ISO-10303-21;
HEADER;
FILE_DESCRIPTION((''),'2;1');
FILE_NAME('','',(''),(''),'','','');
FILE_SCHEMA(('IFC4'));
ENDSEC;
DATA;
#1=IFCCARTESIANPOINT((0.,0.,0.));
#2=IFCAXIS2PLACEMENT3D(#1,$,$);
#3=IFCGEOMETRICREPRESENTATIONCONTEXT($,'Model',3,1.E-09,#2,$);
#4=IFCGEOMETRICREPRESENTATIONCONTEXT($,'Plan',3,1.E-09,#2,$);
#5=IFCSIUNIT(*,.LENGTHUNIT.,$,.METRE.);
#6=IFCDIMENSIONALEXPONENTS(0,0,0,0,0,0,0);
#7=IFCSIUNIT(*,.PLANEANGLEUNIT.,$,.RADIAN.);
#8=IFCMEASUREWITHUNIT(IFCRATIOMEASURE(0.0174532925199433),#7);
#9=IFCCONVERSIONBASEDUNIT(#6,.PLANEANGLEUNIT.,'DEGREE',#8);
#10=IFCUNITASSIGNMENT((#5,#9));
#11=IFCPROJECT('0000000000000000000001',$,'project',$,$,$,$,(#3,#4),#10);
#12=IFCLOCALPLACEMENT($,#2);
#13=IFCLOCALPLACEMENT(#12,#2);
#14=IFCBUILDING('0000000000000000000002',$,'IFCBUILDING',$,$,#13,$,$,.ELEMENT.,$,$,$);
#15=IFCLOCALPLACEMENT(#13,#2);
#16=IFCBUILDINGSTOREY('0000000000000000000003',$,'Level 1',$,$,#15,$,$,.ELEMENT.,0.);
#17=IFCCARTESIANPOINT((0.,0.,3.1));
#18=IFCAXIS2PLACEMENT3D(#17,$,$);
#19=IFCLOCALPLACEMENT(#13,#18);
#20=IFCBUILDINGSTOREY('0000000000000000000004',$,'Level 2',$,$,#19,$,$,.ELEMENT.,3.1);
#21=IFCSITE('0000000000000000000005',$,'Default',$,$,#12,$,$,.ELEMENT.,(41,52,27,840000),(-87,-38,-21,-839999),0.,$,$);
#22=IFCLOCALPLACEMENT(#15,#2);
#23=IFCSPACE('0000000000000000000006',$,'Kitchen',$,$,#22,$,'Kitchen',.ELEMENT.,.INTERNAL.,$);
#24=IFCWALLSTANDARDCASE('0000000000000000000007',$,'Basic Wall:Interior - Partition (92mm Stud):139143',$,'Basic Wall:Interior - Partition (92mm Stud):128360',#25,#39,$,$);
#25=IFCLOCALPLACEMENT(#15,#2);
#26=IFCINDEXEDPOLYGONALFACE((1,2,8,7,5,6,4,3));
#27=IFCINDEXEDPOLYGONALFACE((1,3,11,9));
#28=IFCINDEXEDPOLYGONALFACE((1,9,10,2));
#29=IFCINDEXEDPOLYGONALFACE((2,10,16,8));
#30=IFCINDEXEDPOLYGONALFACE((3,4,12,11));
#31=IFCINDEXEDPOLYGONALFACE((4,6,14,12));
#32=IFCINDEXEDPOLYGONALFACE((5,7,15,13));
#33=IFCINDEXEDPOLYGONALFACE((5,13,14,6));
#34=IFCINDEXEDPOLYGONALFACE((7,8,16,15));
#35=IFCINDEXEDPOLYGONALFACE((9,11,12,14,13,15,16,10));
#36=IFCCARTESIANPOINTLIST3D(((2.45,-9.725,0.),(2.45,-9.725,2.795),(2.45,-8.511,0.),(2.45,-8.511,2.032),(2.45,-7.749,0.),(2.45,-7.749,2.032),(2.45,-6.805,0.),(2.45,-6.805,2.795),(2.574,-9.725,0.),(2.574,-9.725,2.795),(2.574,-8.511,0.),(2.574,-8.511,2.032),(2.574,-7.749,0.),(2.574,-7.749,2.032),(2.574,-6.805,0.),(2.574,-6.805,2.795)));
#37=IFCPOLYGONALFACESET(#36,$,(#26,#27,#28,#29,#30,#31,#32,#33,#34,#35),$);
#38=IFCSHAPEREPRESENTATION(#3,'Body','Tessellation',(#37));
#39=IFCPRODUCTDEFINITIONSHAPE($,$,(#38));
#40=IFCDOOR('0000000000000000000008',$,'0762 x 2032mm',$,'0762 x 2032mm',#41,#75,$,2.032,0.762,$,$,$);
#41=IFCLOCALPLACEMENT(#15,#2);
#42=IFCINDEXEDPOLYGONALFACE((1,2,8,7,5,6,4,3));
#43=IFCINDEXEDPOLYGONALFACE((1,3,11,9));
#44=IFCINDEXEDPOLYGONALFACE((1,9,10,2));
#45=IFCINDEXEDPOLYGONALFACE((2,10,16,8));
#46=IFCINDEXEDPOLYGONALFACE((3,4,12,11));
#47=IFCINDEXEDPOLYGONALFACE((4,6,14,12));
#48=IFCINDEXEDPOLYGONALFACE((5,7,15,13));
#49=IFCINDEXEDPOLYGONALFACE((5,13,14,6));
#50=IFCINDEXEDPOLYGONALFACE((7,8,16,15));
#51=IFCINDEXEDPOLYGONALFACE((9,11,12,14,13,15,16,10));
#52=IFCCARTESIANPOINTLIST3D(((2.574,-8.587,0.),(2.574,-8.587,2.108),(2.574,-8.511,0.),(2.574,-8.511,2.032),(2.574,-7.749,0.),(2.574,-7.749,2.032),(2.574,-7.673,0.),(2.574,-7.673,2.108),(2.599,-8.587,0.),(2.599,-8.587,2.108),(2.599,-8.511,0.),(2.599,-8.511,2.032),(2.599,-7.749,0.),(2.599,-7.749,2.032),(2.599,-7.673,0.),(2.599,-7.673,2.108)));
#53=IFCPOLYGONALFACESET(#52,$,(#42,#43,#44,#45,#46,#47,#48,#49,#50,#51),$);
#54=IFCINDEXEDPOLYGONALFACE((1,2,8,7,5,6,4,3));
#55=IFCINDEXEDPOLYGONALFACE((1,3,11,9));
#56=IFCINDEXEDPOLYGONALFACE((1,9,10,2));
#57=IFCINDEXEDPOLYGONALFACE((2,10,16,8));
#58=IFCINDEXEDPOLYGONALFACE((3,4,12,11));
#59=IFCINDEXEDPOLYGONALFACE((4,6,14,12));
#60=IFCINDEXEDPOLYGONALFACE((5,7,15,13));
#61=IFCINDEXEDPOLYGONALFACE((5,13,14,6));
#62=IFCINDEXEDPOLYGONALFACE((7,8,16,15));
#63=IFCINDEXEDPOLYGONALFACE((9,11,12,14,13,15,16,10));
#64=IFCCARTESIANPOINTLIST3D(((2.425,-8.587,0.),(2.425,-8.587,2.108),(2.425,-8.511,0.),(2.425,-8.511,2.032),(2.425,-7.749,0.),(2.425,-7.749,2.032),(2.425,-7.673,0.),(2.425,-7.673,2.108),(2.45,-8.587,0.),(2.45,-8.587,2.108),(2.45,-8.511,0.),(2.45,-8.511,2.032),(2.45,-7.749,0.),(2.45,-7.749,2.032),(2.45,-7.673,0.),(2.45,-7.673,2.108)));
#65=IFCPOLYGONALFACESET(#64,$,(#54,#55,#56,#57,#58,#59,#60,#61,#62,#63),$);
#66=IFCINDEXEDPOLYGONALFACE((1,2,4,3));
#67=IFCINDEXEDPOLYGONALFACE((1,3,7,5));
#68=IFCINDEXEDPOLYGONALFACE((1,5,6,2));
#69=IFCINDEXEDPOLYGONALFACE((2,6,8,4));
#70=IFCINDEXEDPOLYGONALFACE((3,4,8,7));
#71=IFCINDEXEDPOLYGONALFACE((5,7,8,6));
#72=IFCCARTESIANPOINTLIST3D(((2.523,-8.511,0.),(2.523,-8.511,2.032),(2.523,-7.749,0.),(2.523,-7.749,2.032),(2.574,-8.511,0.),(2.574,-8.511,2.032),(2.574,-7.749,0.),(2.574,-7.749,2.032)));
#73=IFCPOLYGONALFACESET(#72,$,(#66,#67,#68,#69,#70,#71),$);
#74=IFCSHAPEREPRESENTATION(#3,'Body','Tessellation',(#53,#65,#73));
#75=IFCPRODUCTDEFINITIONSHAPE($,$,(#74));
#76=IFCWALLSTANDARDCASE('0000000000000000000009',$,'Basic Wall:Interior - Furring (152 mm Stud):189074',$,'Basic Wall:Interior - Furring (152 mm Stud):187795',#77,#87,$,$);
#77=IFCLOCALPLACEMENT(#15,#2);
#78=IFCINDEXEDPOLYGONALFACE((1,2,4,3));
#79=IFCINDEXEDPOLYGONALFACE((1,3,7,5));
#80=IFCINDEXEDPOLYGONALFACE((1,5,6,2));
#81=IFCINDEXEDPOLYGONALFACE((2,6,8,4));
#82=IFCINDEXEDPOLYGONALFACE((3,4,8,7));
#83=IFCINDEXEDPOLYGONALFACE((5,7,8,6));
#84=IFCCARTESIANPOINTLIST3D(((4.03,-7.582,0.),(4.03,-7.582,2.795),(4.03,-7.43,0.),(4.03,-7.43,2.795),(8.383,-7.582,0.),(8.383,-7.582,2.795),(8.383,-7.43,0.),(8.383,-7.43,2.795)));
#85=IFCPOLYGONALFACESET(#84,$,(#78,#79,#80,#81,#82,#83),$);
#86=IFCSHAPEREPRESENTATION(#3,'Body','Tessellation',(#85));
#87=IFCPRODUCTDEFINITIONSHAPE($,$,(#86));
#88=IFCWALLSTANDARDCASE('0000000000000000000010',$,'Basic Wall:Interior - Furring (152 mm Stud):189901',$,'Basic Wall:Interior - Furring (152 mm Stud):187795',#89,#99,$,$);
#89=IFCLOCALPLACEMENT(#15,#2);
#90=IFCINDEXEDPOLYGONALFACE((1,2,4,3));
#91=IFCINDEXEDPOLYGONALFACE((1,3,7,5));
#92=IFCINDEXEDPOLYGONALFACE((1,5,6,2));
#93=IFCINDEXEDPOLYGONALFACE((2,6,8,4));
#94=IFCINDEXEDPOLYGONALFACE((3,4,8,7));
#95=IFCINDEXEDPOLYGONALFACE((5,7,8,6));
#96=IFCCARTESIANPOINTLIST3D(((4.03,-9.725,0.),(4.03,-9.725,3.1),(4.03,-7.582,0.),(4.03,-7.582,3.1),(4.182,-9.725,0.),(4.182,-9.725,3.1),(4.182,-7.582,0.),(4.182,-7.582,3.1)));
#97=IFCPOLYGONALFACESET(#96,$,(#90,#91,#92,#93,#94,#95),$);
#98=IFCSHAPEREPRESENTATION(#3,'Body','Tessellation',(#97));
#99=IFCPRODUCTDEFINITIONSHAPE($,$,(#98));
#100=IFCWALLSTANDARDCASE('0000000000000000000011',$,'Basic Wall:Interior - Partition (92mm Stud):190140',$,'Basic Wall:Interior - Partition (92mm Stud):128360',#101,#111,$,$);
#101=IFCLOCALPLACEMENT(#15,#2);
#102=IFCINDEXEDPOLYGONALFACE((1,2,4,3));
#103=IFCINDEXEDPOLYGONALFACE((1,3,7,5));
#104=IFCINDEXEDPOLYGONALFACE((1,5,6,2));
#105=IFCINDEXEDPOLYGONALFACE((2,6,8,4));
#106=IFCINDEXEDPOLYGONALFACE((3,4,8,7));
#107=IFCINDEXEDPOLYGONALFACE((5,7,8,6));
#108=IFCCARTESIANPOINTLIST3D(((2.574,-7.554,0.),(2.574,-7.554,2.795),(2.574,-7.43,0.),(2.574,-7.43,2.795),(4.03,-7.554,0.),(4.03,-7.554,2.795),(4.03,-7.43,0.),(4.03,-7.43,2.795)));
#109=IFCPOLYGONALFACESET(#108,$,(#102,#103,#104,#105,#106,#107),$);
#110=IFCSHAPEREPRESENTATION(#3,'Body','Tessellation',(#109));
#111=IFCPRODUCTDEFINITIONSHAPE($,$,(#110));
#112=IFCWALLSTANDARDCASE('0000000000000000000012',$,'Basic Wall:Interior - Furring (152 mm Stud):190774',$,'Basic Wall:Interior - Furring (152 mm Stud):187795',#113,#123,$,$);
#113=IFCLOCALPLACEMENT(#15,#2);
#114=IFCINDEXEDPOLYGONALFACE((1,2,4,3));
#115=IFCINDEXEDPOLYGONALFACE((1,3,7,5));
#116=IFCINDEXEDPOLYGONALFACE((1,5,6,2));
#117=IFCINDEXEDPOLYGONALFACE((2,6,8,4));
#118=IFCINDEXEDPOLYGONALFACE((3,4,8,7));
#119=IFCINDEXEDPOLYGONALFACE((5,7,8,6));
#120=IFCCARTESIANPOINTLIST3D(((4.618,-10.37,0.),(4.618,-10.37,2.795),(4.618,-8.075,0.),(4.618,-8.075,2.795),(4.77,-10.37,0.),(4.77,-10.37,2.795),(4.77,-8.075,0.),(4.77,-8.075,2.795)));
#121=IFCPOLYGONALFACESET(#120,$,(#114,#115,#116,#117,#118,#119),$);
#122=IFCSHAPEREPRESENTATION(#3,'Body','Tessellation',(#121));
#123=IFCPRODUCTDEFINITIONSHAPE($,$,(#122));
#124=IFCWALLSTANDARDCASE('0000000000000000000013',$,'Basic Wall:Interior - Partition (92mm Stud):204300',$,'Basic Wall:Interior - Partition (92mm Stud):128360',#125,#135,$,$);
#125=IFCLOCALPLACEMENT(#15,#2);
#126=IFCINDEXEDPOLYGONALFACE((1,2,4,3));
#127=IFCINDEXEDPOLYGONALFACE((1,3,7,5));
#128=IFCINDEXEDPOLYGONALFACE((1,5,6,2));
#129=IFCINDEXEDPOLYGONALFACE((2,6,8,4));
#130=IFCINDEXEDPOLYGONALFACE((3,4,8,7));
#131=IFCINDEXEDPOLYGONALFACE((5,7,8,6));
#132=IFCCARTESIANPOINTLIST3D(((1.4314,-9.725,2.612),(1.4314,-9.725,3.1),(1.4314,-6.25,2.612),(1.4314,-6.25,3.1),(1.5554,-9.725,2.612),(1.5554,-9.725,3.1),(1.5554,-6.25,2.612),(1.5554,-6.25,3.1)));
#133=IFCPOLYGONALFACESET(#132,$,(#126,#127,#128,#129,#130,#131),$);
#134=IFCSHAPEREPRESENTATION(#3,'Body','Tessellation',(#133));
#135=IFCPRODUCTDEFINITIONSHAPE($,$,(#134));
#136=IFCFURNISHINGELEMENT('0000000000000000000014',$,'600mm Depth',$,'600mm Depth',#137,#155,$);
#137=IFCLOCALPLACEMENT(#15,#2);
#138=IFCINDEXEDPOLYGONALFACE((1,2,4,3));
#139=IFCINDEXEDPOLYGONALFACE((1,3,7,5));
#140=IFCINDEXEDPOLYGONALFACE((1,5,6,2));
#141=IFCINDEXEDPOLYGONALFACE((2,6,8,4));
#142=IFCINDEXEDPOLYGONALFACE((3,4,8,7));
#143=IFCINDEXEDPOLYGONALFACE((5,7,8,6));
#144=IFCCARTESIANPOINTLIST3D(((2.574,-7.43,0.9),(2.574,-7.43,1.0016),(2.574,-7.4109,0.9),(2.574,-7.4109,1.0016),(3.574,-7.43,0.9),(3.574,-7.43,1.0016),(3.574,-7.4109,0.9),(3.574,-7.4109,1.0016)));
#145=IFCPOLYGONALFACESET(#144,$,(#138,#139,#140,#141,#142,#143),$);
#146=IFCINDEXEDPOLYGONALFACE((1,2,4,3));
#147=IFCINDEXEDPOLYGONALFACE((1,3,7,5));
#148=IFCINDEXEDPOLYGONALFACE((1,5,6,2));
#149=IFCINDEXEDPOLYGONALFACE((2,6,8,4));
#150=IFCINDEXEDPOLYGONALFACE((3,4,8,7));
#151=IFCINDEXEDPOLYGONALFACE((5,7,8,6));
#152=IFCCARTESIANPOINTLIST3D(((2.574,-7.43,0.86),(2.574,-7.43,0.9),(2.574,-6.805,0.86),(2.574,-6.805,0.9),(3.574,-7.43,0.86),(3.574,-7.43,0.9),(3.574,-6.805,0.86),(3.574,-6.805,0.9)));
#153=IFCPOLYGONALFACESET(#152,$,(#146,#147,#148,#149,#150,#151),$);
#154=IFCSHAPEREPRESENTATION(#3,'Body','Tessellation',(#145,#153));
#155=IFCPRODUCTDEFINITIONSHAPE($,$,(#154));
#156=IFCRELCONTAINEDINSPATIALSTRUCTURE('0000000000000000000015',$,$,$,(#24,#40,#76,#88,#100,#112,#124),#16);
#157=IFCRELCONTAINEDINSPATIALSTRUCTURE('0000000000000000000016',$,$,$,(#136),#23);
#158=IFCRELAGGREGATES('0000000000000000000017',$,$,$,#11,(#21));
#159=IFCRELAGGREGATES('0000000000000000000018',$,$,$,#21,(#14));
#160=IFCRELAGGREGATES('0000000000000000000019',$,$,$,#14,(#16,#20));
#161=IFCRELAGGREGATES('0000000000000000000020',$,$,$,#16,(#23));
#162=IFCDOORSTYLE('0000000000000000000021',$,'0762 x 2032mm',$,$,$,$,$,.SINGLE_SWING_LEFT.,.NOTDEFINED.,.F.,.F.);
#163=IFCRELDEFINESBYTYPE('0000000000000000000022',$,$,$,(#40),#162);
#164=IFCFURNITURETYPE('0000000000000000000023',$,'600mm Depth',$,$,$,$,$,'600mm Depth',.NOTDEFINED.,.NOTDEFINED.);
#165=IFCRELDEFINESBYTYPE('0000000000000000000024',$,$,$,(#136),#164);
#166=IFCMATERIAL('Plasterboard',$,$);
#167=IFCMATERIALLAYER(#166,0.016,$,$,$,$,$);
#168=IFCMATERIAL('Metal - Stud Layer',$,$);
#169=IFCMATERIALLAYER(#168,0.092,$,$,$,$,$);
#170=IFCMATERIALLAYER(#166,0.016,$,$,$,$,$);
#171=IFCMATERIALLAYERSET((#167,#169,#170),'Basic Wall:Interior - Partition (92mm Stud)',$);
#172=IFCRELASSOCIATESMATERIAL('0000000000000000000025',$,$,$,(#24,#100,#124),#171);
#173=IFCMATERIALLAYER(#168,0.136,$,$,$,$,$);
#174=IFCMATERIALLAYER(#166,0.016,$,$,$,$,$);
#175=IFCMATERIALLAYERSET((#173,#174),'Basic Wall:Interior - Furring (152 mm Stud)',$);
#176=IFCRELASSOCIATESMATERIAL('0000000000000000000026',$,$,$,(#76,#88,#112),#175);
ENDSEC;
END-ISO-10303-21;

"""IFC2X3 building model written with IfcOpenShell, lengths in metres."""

from ifc_helpers import new_model, entity, si_unit, converted_unit, frame, frame_2d, origin, origin_2d_with_axis, place, context, project, spatial, polyline, rectangle, outline, extrude, clip, bounded_halfspace, source, transform, mapped, material, layer, layer_set, layer_usage, type_object, type_shapes, element, fill, save


model = new_model("IFC2X3")

# Units and contexts
model_context = context("Model", 3, precision=1e-09, world=origin())
plan_context = context("Plan", 3, precision=1e-09, world=origin())
ifc_project = project(units=[si_unit("LENGTHUNIT", "METRE"), converted_unit("PLANEANGLEUNIT", "DEGREE", entity("IfcRatioMeasure", 0.0174532925199433), si_unit("PLANEANGLEUNIT", "RADIAN"), dimensions=[0, 0, 0, 0, 0, 0, 0])], contexts=[model_context, plan_context])

# Site, building, storey
site_placement = place(None, origin())
site = spatial("IfcSite", under=ifc_project, at=site_placement, Name="Default", CompositionType="ELEMENT", RefLatitude=(41, 52, 27, 840000), RefLongitude=(-87, -38, -21, -839999), RefElevation=0.0)
building_placement = place(site_placement, origin())
building = spatial("IfcBuilding", under=site, at=building_placement, Name="IFCBUILDING", CompositionType="ELEMENT")
storey_1_placement = place(building_placement, origin())
storey_1 = spatial("IfcBuildingStorey", under=building, at=storey_1_placement, Name="Level 1", CompositionType="ELEMENT", Elevation=0.0)

# Shared definitions
ifc_material_1 = material(Name="Metal - Stud Layer")
ifc_material_2 = material(Name="Plasterboard")

# Shared definitions
ifc_layer_1 = layer(ifc_material_2, 0.016)
ifc_layer_2 = layer(ifc_material_1, 0.092)
ifc_layer_3 = layer(ifc_material_2, 0.016)
ifc_layer_set_1 = layer_set([ifc_layer_1, ifc_layer_2, ifc_layer_3], Name="Basic Wall:Interior - Partition (92mm Stud)")

# Wall, opening, door
ifc_layer_usage_1 = layer_usage(ifc_layer_set_1, "AXIS2", "NEGATIVE", 0.062)
wall_1_placement = place(storey_1_placement, frame((2.512, -6.805, 0.0), z_axis=(0.0, 0.0, 1.0), x_axis=(0.0, -1.0, 0.0)))
wall_1 = element("IfcWallStandardCase", 1, at=wall_1_placement, inside=storey_1, material=ifc_layer_usage_1, Name="Basic Wall:Interior - Partition (92mm Stud):139143", ObjectType="Basic Wall:Interior - Partition (92mm Stud):128360", context=model_context, shape_type="SweptSolid", body=[
    extrude(rectangle(XDim=2.92, YDim=0.124, at=frame_2d((1.46, 0.0), x_axis=(-1.0, 0.0))), origin(), (0.0, 0.0, 1.0), 2.795),
])
opening_1_placement = place(wall_1_placement, frame((0.944, -0.062, 0.0)))
opening_1 = element("IfcOpeningElement", 2, at=opening_1_placement, cuts=wall_1, ObjectType="Opening", context=model_context, shape_type="SweptSolid", body=[
    extrude(rectangle(XDim=0.762, YDim=2.032, at=frame_2d((1.016, 0.381), x_axis=(0.0, -1.0))), frame((0.0, 0.0, 0.0), z_axis=(0.0, 1.0, 0.0), x_axis=(0.0, 0.0, 1.0)), (0.0, 0.0, 1.0), 0.124),
])
door_style_1 = type_object("IfcDoorStyle", Name="0762 x 2032mm", ConstructionType="NOTDEFINED", OperationType="SINGLE_SWING_LEFT", ParameterTakesPrecedence=False, Sizeable=False)
shared_shape_1 = source(origin(), model_context, "Body", "SweptSolid", [
    extrude(outline(polyline([(-0.457, -1.073), (0.457, -1.073), (0.457, 1.035), (0.381, 1.035), (0.381, -0.997), (-0.381, -0.997), (-0.381, 1.035), (-0.457, 1.035), (-0.457, -1.073)])), frame((0.381, 0.149, 1.035), z_axis=(0.0, -1.0, 0.0), x_axis=(-1.0, 0.0, 0.0)), (0.0, 0.0, 1.0), 0.025),
    extrude(outline(polyline([(-1.073, -0.457), (1.035, -0.457), (1.035, -0.381), (-0.997, -0.381), (-0.997, 0.381), (1.035, 0.381), (1.035, 0.457), (-1.073, 0.457), (-1.073, -0.457)])), frame((0.381, 0.0, 1.035), z_axis=(0.0, -1.0, 0.0), x_axis=(0.0, 0.0, -1.0)), (0.0, 0.0, 1.0), 0.025),
    extrude(rectangle(XDim=0.762, YDim=0.051, at=origin_2d_with_axis()), frame((0.381, 0.0985, 0.0)), (0.0, 0.0, 1.0), 2.032),
])
type_shapes(door_style_1, [shared_shape_1])
door_1_placement = place(opening_1_placement, origin())
door_1 = element("IfcDoor", 3, at=door_1_placement, inside=storey_1, type_object=door_style_1, Name="0762 x 2032mm", ObjectType="0762 x 2032mm", OverallHeight=2.032, OverallWidth=0.762, context=model_context, shape_type="MappedRepresentation", body=[
    mapped(shared_shape_1, transform((0.0, 0.0, 0.0), scale=1.0)),
])
fill(opening_1, door_1)

# Shared definitions
storey_2_placement = place(building_placement, frame((0.0, 0.0, 3.1)))
storey_2 = spatial("IfcBuildingStorey", under=building, at=storey_2_placement, Name="Level 2", CompositionType="ELEMENT", Elevation=3.1)

# Walls
ifc_layer_4 = layer(ifc_material_1, 0.136)
ifc_layer_5 = layer(ifc_material_2, 0.016)
ifc_layer_set_2 = layer_set([ifc_layer_4, ifc_layer_5], Name="Basic Wall:Interior - Furring (152 mm Stud)")
ifc_layer_usage_2 = layer_usage(ifc_layer_set_2, "AXIS2", "NEGATIVE", 0.076)
wall_2_placement = place(storey_1_placement, frame((8.383, -7.506, 0.0), z_axis=(0.0, 0.0, 1.0), x_axis=(-1.0, 0.0, 0.0)))
element("IfcWallStandardCase", 4, at=wall_2_placement, inside=storey_1, material=ifc_layer_usage_2, Name="Basic Wall:Interior - Furring (152 mm Stud):189074", ObjectType="Basic Wall:Interior - Furring (152 mm Stud):187795", context=model_context, shape_type="Clipping", body=[
    clip(extrude(rectangle(XDim=4.353, YDim=0.152, at=frame_2d((2.1765, 0.0), x_axis=(-1.0, 0.0))), origin(), (0.0, 0.0, 1.0), 2.795), bounded_halfspace(frame((0.0, -0.076, 2.795), z_axis=(0.0, 0.0, -1.0), x_axis=(0.0, 1.0, 0.0)), True, frame((0.0, -0.076, 2.795)), polyline([(0.0, 0.0), (3.708, 0.0), (3.708, 0.152), (0.0, 0.152), (0.0, 0.0)]))),
])
ifc_layer_usage_3 = layer_usage(ifc_layer_set_2, "AXIS2", "POSITIVE", -0.076)
wall_3_placement = place(storey_1_placement, frame((4.106, -9.725, 0.0), z_axis=(0.0, 0.0, 1.0), x_axis=(0.0, 1.0, 0.0)))
element("IfcWallStandardCase", 5, at=wall_3_placement, inside=storey_1, material=ifc_layer_usage_3, Name="Basic Wall:Interior - Furring (152 mm Stud):189901", ObjectType="Basic Wall:Interior - Furring (152 mm Stud):187795", context=model_context, shape_type="SweptSolid", body=[
    extrude(rectangle(XDim=2.143, YDim=0.152, at=frame_2d((1.0715, 0.0), x_axis=(-1.0, 0.0))), origin(), (0.0, 0.0, 1.0), 3.1),
])
ifc_layer_usage_4 = layer_usage(ifc_layer_set_1, "AXIS2", "NEGATIVE", 0.062)
wall_4_placement = place(storey_1_placement, frame((4.03, -7.492, 0.0), z_axis=(0.0, 0.0, 1.0), x_axis=(-1.0, 0.0, 0.0)))
element("IfcWallStandardCase", 6, at=wall_4_placement, inside=storey_1, material=ifc_layer_usage_4, Name="Basic Wall:Interior - Partition (92mm Stud):190140", ObjectType="Basic Wall:Interior - Partition (92mm Stud):128360", context=model_context, shape_type="SweptSolid", body=[
    extrude(rectangle(XDim=1.456, YDim=0.124, at=frame_2d((0.728, 0.0), x_axis=(-1.0, 0.0))), origin(), (0.0, 0.0, 1.0), 2.795),
])
ifc_layer_usage_5 = layer_usage(ifc_layer_set_2, "AXIS2", "POSITIVE", -0.076)
wall_5_placement = place(storey_1_placement, frame((4.694, -8.075, 0.0), z_axis=(0.0, 0.0, 1.0), x_axis=(0.0, -1.0, 0.0)))
element("IfcWallStandardCase", 7, at=wall_5_placement, inside=storey_1, material=ifc_layer_usage_5, Name="Basic Wall:Interior - Furring (152 mm Stud):190774", ObjectType="Basic Wall:Interior - Furring (152 mm Stud):187795", context=model_context, shape_type="SweptSolid", body=[
    extrude(rectangle(XDim=2.295, YDim=0.152, at=frame_2d((1.1475, 0.0), x_axis=(-1.0, 0.0))), origin(), (0.0, 0.0, 1.0), 2.795),
])
ifc_layer_usage_6 = layer_usage(ifc_layer_set_1, "AXIS2", "NEGATIVE", 0.062)
wall_6_placement = place(storey_1_placement, frame((1.4934, -6.25, 2.612), z_axis=(0.0, 0.0, 1.0), x_axis=(0.0, -1.0, 0.0)))
element("IfcWallStandardCase", 8, at=wall_6_placement, inside=storey_1, material=ifc_layer_usage_6, Name="Basic Wall:Interior - Partition (92mm Stud):204300", ObjectType="Basic Wall:Interior - Partition (92mm Stud):128360", context=model_context, shape_type="SweptSolid", body=[
    extrude(rectangle(XDim=3.475, YDim=0.124, at=frame_2d((1.7375, 0.0), x_axis=(-1.0, 0.0))), origin(), (0.0, 0.0, 1.0), 0.488),
])

# Shared definitions
space_1_placement = place(storey_1_placement, origin())
space_1 = spatial("IfcSpace", under=storey_1, at=space_1_placement, Name="Kitchen", LongName="Kitchen", CompositionType="ELEMENT", InteriorOrExteriorSpace="INTERNAL")

# Furnishing element
furniture_type_1 = type_object("IfcFurnitureType", Name="600mm Depth", ElementType="600mm Depth", AssemblyPlace="NOTDEFINED")
shared_shape_2 = source(origin(), model_context, "Body", "SweptSolid", [
    extrude(rectangle(XDim=0.0191, YDim=1.0, at=origin_2d_with_axis()), frame((-0.7005, -0.0095, 0.9), z_axis=(0.0, 0.0, 1.0), x_axis=(0.0, -1.0, 0.0)), (0.0, 0.0, 1.0), 0.1016),
    extrude(rectangle(XDim=1.0, YDim=0.625, at=origin_2d_with_axis()), frame((-0.7005, -0.3125, 0.86), z_axis=(0.0, 0.0, 1.0), x_axis=(-1.0, 0.0, 0.0)), (0.0, 0.0, 1.0), 0.04),
])
type_shapes(furniture_type_1, [shared_shape_2])
furnishing_1_placement = place(space_1_placement, frame((2.3735, -7.43, 0.0), z_axis=(0.0, 0.0, 1.0), x_axis=(-1.0, 0.0, 0.0)))
element("IfcFurnishingElement", 9, at=furnishing_1_placement, inside=space_1, type_object=furniture_type_1, Name="600mm Depth", ObjectType="600mm Depth", context=model_context, shape_type="MappedRepresentation", body=[
    mapped(shared_shape_2, transform((0.0, 0.0, 0.0), scale=1.0)),
])

save(model, "model.ifc")
